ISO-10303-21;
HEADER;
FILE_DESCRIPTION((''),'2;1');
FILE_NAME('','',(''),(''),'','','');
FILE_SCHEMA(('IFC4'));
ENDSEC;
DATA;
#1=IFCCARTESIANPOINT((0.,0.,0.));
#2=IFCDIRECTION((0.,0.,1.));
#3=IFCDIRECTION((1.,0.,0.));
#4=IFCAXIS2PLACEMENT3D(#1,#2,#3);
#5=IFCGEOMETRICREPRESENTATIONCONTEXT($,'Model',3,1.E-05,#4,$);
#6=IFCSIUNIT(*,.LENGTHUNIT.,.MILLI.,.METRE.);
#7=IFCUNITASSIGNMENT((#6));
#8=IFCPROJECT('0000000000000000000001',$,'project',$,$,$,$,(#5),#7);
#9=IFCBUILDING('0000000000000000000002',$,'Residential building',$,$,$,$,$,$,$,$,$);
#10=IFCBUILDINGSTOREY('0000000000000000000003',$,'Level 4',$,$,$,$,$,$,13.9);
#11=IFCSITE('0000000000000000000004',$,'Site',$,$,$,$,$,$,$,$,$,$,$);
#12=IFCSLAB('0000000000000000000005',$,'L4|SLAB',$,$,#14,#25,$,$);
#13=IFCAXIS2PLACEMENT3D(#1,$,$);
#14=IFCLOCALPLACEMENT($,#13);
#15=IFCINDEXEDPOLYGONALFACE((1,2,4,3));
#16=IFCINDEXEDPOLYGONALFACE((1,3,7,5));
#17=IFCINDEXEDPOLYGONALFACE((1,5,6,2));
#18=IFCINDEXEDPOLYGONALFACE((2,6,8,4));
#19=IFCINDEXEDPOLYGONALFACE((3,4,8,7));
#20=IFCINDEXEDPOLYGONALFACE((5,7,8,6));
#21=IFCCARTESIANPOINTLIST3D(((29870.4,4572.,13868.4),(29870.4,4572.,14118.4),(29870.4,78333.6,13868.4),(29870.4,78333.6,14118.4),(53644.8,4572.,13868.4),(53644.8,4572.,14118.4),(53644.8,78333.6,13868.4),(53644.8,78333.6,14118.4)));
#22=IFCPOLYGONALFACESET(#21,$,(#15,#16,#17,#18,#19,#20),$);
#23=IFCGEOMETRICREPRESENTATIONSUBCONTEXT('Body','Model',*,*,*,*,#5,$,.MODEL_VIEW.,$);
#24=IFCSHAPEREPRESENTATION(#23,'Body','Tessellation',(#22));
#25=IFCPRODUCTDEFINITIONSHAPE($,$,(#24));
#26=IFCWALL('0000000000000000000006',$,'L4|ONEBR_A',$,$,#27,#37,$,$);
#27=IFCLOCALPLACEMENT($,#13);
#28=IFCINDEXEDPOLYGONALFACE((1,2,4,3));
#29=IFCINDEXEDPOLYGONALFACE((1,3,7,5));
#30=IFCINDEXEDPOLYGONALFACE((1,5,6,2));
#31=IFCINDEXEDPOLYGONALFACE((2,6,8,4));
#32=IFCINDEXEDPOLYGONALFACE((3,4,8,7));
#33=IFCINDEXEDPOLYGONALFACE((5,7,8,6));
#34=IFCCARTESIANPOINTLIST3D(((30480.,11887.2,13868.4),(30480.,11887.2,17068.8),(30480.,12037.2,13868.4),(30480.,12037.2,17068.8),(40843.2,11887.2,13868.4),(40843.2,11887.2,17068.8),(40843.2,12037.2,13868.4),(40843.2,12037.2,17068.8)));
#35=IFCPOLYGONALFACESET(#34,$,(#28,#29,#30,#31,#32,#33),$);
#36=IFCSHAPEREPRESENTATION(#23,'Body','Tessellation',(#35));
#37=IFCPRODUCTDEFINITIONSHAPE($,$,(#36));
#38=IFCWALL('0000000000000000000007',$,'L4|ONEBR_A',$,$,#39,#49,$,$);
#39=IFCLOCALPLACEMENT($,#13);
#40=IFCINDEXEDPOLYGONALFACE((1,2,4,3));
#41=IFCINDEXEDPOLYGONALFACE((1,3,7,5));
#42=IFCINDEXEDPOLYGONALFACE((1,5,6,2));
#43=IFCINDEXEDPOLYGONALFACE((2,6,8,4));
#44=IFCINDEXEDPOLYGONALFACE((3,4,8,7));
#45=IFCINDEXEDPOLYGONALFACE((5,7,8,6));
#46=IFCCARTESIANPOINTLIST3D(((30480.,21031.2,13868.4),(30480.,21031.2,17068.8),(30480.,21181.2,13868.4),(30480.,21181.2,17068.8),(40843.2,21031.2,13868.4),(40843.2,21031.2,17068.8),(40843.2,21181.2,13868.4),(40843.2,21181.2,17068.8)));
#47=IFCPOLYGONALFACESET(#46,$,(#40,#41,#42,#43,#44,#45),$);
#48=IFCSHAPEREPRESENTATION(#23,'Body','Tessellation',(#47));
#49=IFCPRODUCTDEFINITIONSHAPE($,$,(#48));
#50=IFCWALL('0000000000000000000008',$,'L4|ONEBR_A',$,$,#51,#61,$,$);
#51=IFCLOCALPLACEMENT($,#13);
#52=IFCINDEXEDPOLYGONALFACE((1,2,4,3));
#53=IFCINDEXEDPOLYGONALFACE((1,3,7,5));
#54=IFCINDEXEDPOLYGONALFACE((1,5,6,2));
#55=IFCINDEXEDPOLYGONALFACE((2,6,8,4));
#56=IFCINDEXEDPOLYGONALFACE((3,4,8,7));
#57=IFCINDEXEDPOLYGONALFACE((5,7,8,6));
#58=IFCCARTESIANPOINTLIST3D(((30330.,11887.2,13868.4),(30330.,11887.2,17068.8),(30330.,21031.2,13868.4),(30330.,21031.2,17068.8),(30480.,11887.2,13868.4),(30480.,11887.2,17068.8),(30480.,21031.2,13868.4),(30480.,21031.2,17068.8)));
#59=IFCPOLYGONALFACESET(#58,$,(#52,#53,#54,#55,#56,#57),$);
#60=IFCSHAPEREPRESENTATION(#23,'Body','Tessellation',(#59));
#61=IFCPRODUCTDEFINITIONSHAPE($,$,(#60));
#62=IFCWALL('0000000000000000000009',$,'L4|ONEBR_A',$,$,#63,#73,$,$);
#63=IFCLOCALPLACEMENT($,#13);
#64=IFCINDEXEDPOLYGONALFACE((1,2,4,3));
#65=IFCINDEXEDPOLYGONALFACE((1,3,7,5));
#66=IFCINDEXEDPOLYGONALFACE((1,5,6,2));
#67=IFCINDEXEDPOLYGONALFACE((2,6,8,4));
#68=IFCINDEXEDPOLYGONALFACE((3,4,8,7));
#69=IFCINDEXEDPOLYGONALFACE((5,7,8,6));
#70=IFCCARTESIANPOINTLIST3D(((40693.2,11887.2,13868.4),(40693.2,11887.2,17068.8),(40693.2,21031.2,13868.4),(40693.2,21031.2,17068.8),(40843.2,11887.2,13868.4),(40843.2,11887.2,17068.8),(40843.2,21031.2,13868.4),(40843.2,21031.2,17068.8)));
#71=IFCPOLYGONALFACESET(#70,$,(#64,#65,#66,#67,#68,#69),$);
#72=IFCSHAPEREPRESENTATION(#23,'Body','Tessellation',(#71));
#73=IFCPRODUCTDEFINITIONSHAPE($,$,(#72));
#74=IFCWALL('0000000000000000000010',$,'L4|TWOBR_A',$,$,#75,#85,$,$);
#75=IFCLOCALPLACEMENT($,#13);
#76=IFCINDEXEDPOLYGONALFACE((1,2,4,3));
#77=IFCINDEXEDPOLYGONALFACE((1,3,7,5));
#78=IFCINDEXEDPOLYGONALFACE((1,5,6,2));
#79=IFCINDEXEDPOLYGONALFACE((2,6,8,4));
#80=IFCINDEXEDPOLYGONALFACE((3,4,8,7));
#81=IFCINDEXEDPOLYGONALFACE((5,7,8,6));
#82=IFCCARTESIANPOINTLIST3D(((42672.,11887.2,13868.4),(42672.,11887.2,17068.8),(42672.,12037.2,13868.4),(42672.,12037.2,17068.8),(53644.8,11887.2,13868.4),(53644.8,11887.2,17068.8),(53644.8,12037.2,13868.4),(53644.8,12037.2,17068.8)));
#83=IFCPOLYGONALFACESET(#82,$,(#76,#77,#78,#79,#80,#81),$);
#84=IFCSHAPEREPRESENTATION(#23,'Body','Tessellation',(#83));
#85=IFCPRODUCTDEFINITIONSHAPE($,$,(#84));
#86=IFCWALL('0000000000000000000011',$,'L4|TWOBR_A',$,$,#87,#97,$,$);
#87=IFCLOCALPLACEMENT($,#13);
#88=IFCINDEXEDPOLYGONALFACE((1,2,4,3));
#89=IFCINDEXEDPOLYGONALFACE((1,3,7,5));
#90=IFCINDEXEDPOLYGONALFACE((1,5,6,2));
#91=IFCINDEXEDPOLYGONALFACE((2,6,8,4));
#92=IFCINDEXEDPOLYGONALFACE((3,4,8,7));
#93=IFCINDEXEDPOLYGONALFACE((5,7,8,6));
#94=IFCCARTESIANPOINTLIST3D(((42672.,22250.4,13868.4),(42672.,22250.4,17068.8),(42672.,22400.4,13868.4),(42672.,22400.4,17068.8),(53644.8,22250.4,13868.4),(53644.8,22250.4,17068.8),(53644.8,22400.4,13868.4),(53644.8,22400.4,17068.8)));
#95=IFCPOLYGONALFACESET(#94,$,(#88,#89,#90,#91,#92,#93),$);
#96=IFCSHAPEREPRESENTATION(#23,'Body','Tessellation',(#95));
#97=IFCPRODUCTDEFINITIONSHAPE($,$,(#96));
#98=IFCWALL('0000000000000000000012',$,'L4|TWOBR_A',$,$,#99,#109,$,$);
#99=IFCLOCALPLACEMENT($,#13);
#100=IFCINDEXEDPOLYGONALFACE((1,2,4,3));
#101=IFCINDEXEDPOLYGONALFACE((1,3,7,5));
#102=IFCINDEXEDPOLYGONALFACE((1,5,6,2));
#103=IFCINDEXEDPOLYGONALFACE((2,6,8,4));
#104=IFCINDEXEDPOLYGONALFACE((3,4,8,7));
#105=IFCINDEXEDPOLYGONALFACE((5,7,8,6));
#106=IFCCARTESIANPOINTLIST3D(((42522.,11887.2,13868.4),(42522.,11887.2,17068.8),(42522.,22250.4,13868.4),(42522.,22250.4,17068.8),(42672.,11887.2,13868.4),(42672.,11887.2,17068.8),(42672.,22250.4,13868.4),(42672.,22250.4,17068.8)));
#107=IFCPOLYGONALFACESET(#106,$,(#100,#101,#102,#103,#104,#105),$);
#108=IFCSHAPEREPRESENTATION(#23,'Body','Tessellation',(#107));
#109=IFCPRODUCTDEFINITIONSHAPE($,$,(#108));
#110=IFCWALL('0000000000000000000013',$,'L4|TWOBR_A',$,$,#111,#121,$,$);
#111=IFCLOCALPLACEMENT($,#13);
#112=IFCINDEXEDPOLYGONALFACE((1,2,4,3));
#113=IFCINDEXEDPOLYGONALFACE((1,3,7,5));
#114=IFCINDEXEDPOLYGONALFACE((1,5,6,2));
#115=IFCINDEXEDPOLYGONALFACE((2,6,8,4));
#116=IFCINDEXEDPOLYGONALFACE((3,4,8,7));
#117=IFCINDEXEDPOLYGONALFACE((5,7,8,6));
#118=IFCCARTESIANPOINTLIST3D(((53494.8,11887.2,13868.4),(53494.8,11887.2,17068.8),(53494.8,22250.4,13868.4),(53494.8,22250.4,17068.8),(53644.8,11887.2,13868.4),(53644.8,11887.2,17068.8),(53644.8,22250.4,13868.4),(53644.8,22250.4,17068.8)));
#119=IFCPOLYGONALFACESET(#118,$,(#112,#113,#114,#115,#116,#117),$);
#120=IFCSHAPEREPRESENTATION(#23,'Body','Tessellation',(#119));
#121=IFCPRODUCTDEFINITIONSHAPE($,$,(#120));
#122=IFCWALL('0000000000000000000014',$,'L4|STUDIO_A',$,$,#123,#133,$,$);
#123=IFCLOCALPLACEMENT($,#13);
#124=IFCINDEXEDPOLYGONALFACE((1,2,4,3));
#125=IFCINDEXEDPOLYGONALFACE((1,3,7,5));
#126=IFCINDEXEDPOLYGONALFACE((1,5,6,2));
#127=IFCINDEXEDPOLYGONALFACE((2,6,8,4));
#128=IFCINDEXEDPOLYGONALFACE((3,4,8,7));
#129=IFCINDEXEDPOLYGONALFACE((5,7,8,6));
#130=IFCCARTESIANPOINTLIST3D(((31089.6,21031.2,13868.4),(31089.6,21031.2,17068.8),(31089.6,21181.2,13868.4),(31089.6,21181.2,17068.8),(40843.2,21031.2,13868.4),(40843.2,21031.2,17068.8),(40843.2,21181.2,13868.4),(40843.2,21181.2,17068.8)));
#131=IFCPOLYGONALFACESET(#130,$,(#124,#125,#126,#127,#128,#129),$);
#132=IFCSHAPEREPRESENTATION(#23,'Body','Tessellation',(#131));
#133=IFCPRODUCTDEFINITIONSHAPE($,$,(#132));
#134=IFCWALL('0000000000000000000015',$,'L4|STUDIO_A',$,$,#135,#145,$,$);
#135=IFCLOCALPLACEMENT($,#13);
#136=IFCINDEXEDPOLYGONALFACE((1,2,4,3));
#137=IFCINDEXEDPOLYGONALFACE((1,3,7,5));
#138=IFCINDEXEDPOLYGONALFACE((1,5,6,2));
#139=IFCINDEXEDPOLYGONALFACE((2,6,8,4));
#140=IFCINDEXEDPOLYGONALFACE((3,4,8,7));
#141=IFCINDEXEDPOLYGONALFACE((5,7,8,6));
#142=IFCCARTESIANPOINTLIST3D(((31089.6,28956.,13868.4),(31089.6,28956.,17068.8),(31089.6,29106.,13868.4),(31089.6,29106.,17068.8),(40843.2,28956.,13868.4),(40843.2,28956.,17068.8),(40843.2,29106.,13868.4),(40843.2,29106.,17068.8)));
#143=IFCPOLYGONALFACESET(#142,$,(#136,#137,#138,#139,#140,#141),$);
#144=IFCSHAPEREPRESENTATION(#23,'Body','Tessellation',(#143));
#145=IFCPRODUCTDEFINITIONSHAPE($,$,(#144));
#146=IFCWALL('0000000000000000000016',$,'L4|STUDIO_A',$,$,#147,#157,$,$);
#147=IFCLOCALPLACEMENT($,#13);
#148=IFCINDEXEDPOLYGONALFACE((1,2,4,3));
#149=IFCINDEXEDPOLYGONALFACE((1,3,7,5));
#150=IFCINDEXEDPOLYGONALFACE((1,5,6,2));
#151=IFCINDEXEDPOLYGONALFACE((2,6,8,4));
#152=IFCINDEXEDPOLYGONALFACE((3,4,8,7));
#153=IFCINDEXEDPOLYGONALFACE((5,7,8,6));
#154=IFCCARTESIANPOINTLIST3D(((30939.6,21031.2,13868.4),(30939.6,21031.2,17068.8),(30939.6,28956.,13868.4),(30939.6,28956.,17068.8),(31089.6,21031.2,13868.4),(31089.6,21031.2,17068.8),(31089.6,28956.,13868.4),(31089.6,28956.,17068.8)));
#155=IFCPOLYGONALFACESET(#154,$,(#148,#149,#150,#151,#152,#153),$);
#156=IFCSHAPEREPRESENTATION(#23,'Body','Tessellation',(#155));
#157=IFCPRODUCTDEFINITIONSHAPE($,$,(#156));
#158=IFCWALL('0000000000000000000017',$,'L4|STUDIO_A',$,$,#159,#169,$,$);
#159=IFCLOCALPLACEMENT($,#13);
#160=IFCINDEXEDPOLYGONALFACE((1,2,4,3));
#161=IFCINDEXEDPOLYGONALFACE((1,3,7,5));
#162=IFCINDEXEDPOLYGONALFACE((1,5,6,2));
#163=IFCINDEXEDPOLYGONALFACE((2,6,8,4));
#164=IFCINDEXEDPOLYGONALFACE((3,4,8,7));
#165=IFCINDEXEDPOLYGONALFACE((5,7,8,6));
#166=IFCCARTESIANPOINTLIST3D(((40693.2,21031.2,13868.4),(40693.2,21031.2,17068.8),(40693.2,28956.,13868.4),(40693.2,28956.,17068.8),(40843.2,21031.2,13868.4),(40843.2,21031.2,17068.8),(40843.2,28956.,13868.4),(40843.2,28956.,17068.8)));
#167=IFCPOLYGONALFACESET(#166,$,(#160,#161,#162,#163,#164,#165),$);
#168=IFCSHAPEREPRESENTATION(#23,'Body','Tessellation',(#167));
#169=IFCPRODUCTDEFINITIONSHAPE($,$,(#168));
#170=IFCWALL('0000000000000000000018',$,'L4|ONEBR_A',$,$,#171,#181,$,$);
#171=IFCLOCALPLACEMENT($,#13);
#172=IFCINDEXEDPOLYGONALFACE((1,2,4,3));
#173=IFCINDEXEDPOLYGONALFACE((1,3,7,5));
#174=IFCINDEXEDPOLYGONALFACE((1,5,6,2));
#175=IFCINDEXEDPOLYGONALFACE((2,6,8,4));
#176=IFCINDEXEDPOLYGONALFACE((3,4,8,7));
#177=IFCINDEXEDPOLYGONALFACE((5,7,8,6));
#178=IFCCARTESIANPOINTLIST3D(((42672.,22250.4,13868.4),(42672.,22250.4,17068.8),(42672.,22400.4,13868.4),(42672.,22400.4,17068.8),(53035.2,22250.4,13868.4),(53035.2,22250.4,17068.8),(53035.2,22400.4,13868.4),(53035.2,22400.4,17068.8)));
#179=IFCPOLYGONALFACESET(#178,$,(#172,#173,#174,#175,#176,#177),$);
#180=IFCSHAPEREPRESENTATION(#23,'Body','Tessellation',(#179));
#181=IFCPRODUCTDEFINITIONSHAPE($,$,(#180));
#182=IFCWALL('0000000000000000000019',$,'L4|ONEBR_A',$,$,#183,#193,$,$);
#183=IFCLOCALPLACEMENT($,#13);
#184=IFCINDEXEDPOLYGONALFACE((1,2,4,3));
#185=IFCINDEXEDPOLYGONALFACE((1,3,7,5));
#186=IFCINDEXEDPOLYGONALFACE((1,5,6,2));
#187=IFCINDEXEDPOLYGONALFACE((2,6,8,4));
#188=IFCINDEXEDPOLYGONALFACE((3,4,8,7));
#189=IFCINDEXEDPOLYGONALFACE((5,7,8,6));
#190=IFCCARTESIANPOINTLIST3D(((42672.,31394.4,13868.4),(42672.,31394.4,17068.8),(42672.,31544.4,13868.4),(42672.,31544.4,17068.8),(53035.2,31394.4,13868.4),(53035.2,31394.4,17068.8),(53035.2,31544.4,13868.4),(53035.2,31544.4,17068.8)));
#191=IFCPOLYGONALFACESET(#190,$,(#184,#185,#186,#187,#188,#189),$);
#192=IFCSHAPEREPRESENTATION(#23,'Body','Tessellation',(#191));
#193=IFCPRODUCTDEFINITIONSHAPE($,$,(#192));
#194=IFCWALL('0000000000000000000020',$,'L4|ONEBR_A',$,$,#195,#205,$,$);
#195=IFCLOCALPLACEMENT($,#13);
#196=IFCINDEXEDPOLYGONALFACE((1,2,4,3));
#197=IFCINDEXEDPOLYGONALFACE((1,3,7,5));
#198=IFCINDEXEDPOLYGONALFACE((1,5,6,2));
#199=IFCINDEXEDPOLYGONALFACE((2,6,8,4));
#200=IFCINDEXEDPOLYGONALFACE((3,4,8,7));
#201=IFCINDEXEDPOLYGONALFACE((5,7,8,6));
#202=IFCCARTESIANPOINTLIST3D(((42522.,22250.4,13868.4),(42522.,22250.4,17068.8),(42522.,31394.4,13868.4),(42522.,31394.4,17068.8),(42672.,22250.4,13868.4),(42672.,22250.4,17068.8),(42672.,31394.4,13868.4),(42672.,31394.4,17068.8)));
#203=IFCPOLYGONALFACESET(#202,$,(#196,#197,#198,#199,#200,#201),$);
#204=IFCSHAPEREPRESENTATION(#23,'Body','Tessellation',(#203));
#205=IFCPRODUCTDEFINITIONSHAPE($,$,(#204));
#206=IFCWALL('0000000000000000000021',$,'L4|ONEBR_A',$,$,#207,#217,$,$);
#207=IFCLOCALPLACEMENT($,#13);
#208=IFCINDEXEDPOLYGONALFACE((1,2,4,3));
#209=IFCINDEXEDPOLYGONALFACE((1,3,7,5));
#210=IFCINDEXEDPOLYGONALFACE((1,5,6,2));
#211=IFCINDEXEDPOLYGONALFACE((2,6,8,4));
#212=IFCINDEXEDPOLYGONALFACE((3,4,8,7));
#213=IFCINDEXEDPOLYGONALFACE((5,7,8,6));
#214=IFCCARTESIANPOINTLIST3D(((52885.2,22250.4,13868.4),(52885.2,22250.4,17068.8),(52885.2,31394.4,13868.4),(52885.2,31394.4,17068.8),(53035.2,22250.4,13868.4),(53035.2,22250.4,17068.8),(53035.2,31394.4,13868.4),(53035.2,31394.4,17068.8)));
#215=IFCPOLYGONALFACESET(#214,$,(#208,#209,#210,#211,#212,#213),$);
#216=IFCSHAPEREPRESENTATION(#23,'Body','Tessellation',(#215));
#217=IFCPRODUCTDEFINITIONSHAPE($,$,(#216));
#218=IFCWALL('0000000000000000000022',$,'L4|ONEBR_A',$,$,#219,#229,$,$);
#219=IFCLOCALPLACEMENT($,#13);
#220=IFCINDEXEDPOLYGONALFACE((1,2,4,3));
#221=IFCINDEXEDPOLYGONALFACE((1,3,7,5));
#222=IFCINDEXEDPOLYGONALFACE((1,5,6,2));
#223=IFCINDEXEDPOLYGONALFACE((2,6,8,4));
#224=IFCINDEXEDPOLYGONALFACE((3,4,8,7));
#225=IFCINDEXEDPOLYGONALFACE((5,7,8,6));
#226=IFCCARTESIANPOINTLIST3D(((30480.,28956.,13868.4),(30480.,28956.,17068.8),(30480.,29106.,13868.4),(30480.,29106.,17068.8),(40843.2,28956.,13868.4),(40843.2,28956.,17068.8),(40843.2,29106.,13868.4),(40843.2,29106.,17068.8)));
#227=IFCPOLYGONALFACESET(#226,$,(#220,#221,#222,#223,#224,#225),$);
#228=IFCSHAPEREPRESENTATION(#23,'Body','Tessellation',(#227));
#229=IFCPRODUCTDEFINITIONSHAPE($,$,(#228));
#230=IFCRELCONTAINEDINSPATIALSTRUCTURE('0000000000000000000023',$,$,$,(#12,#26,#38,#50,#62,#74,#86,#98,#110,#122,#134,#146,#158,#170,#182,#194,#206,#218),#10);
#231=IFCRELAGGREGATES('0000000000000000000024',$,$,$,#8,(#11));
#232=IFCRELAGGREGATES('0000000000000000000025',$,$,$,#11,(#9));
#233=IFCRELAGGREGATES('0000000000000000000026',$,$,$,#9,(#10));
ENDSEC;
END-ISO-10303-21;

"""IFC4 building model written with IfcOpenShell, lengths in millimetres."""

from ifc_helpers import new_model, si_unit, frame, origin_with_axes, place, context, subcontext, project, spatial, indexed_curve, outline, extrude, element, save


model = new_model("IFC4")

# Units and contexts
model_context = context("Model", 3, precision=1e-05, world=origin_with_axes())
body_context = subcontext(model_context, "Body", "Model", "MODEL_VIEW")
ifc_project = project(units=[si_unit("LENGTHUNIT", "METRE", prefix="MILLI")], contexts=[model_context])

# Site, building, storey
site = spatial("IfcSite", under=ifc_project, Name="Site")
building = spatial("IfcBuilding", under=site, Name="Residential building")
storey = spatial("IfcBuildingStorey", under=building, Name="Level 4", Elevation=13.9)

# Slab
slab_placement = place(None, frame((29870.4, 4572.0, 13868.4), z_axis=(0.0, 0.0, 1.0), x_axis=(1.0, 0.0, 0.0)))
element("IfcSlab", 1, at=slab_placement, inside=storey, Name="L4|SLAB", context=body_context, shape_type="SweptSolid", body=[
    extrude(outline(indexed_curve([(0.0, 0.0), (23774.4, 0.0), (23774.4, 73761.6), (0.0, 73761.6), (0.0, 0.0)])), None, (0.0, 0.0, 1.0), 250.0),
])

# Walls
for number, where, z_axis, x_axis, name in (
    (2, (30480.0, 11887.2, 13868.4), (0.0, 0.0, 1.0), (1.0, 0.0, 0.0), "L4|ONEBR_A"),
    (3, (30480.0, 21031.2, 13868.4), (0.0, 0.0, 1.0), (1.0, 0.0, 0.0), "L4|ONEBR_A"),
):
    element("IfcWall", number, at=place(None, frame(where, z_axis=z_axis, x_axis=x_axis)), inside=storey, Name=name, context=body_context, shape_type="SweptSolid", body=[
        extrude(outline(indexed_curve([(0.0, 0.0), (0.0, 150.0), (10363.2, 150.0), (10363.2, 0.0), (0.0, 0.0)], self_intersect=False)), origin_with_axes(), (0.0, 0.0, 1.0), 3200.4),
    ])
for number, where, z_axis, x_axis, name in (
    (4, (30480.0, 11887.2, 13868.4), (0.0, 0.0, 1.0), (0.0, 1.0, 0.0), "L4|ONEBR_A"),
    (5, (40843.2, 11887.2, 13868.4), (0.0, 0.0, 1.0), (0.0, 1.0, 0.0), "L4|ONEBR_A"),
):
    element("IfcWall", number, at=place(None, frame(where, z_axis=z_axis, x_axis=x_axis)), inside=storey, Name=name, context=body_context, shape_type="SweptSolid", body=[
        extrude(outline(indexed_curve([(0.0, 0.0), (0.0, 150.0), (9144.0, 150.0), (9144.0, 0.0), (0.0, 0.0)], self_intersect=False)), origin_with_axes(), (0.0, 0.0, 1.0), 3200.4),
    ])
for number, where, z_axis, x_axis, name in (
    (6, (42672.0, 11887.2, 13868.4), (0.0, 0.0, 1.0), (1.0, 0.0, 0.0), "L4|TWOBR_A"),
    (7, (42672.0, 22250.4, 13868.4), (0.0, 0.0, 1.0), (1.0, 0.0, 0.0), "L4|TWOBR_A"),
):
    element("IfcWall", number, at=place(None, frame(where, z_axis=z_axis, x_axis=x_axis)), inside=storey, Name=name, context=body_context, shape_type="SweptSolid", body=[
        extrude(outline(indexed_curve([(0.0, 0.0), (0.0, 150.0), (10972.8, 150.0), (10972.8, 0.0), (0.0, 0.0)], self_intersect=False)), origin_with_axes(), (0.0, 0.0, 1.0), 3200.4),
    ])
for number, where, z_axis, x_axis, name in (
    (8, (42672.0, 11887.2, 13868.4), (0.0, 0.0, 1.0), (0.0, 1.0, 0.0), "L4|TWOBR_A"),
    (9, (53644.8, 11887.2, 13868.4), (0.0, 0.0, 1.0), (0.0, 1.0, 0.0), "L4|TWOBR_A"),
):
    element("IfcWall", number, at=place(None, frame(where, z_axis=z_axis, x_axis=x_axis)), inside=storey, Name=name, context=body_context, shape_type="SweptSolid", body=[
        extrude(outline(indexed_curve([(0.0, 0.0), (0.0, 150.0), (10363.2, 150.0), (10363.2, 0.0), (0.0, 0.0)], self_intersect=False)), origin_with_axes(), (0.0, 0.0, 1.0), 3200.4),
    ])
for number, where, z_axis, x_axis, name in (
    (10, (31089.6, 21031.2, 13868.4), (0.0, 0.0, 1.0), (1.0, 0.0, 0.0), "L4|STUDIO_A"),
    (11, (31089.6, 28956.0, 13868.4), (0.0, 0.0, 1.0), (1.0, 0.0, 0.0), "L4|STUDIO_A"),
):
    element("IfcWall", number, at=place(None, frame(where, z_axis=z_axis, x_axis=x_axis)), inside=storey, Name=name, context=body_context, shape_type="SweptSolid", body=[
        extrude(outline(indexed_curve([(0.0, 0.0), (0.0, 150.0), (9753.6, 150.0), (9753.6, 0.0), (0.0, 0.0)], self_intersect=False)), origin_with_axes(), (0.0, 0.0, 1.0), 3200.4),
    ])
for number, where, z_axis, x_axis, name in (
    (12, (31089.6, 21031.2, 13868.4), (0.0, 0.0, 1.0), (0.0, 1.0, 0.0), "L4|STUDIO_A"),
    (13, (40843.2, 21031.2, 13868.4), (0.0, 0.0, 1.0), (0.0, 1.0, 0.0), "L4|STUDIO_A"),
):
    element("IfcWall", number, at=place(None, frame(where, z_axis=z_axis, x_axis=x_axis)), inside=storey, Name=name, context=body_context, shape_type="SweptSolid", body=[
        extrude(outline(indexed_curve([(0.0, 0.0), (0.0, 150.0), (7924.8, 150.0), (7924.8, 0.0), (0.0, 0.0)], self_intersect=False)), origin_with_axes(), (0.0, 0.0, 1.0), 3200.4),
    ])
for number, where, z_axis, x_axis, name in (
    (14, (42672.0, 22250.4, 13868.4), (0.0, 0.0, 1.0), (1.0, 0.0, 0.0), "L4|ONEBR_A"),
    (15, (42672.0, 31394.4, 13868.4), (0.0, 0.0, 1.0), (1.0, 0.0, 0.0), "L4|ONEBR_A"),
):
    element("IfcWall", number, at=place(None, frame(where, z_axis=z_axis, x_axis=x_axis)), inside=storey, Name=name, context=body_context, shape_type="SweptSolid", body=[
        extrude(outline(indexed_curve([(0.0, 0.0), (0.0, 150.0), (10363.2, 150.0), (10363.2, 0.0), (0.0, 0.0)], self_intersect=False)), origin_with_axes(), (0.0, 0.0, 1.0), 3200.4),
    ])
for number, where, z_axis, x_axis, name in (
    (16, (42672.0, 22250.4, 13868.4), (0.0, 0.0, 1.0), (0.0, 1.0, 0.0), "L4|ONEBR_A"),
    (17, (53035.2, 22250.4, 13868.4), (0.0, 0.0, 1.0), (0.0, 1.0, 0.0), "L4|ONEBR_A"),
):
    element("IfcWall", number, at=place(None, frame(where, z_axis=z_axis, x_axis=x_axis)), inside=storey, Name=name, context=body_context, shape_type="SweptSolid", body=[
        extrude(outline(indexed_curve([(0.0, 0.0), (0.0, 150.0), (9144.0, 150.0), (9144.0, 0.0), (0.0, 0.0)], self_intersect=False)), origin_with_axes(), (0.0, 0.0, 1.0), 3200.4),
    ])
wall_1_placement = place(None, frame((30480.0, 28956.0, 13868.4), z_axis=(0.0, 0.0, 1.0), x_axis=(1.0, 0.0, 0.0)))
element("IfcWall", 18, at=wall_1_placement, inside=storey, Name="L4|ONEBR_A", context=body_context, shape_type="SweptSolid", body=[
    extrude(outline(indexed_curve([(0.0, 0.0), (0.0, 150.0), (10363.2, 150.0), (10363.2, 0.0), (0.0, 0.0)], self_intersect=False)), origin_with_axes(), (0.0, 0.0, 1.0), 3200.4),
])

save(model, "model.ifc")
